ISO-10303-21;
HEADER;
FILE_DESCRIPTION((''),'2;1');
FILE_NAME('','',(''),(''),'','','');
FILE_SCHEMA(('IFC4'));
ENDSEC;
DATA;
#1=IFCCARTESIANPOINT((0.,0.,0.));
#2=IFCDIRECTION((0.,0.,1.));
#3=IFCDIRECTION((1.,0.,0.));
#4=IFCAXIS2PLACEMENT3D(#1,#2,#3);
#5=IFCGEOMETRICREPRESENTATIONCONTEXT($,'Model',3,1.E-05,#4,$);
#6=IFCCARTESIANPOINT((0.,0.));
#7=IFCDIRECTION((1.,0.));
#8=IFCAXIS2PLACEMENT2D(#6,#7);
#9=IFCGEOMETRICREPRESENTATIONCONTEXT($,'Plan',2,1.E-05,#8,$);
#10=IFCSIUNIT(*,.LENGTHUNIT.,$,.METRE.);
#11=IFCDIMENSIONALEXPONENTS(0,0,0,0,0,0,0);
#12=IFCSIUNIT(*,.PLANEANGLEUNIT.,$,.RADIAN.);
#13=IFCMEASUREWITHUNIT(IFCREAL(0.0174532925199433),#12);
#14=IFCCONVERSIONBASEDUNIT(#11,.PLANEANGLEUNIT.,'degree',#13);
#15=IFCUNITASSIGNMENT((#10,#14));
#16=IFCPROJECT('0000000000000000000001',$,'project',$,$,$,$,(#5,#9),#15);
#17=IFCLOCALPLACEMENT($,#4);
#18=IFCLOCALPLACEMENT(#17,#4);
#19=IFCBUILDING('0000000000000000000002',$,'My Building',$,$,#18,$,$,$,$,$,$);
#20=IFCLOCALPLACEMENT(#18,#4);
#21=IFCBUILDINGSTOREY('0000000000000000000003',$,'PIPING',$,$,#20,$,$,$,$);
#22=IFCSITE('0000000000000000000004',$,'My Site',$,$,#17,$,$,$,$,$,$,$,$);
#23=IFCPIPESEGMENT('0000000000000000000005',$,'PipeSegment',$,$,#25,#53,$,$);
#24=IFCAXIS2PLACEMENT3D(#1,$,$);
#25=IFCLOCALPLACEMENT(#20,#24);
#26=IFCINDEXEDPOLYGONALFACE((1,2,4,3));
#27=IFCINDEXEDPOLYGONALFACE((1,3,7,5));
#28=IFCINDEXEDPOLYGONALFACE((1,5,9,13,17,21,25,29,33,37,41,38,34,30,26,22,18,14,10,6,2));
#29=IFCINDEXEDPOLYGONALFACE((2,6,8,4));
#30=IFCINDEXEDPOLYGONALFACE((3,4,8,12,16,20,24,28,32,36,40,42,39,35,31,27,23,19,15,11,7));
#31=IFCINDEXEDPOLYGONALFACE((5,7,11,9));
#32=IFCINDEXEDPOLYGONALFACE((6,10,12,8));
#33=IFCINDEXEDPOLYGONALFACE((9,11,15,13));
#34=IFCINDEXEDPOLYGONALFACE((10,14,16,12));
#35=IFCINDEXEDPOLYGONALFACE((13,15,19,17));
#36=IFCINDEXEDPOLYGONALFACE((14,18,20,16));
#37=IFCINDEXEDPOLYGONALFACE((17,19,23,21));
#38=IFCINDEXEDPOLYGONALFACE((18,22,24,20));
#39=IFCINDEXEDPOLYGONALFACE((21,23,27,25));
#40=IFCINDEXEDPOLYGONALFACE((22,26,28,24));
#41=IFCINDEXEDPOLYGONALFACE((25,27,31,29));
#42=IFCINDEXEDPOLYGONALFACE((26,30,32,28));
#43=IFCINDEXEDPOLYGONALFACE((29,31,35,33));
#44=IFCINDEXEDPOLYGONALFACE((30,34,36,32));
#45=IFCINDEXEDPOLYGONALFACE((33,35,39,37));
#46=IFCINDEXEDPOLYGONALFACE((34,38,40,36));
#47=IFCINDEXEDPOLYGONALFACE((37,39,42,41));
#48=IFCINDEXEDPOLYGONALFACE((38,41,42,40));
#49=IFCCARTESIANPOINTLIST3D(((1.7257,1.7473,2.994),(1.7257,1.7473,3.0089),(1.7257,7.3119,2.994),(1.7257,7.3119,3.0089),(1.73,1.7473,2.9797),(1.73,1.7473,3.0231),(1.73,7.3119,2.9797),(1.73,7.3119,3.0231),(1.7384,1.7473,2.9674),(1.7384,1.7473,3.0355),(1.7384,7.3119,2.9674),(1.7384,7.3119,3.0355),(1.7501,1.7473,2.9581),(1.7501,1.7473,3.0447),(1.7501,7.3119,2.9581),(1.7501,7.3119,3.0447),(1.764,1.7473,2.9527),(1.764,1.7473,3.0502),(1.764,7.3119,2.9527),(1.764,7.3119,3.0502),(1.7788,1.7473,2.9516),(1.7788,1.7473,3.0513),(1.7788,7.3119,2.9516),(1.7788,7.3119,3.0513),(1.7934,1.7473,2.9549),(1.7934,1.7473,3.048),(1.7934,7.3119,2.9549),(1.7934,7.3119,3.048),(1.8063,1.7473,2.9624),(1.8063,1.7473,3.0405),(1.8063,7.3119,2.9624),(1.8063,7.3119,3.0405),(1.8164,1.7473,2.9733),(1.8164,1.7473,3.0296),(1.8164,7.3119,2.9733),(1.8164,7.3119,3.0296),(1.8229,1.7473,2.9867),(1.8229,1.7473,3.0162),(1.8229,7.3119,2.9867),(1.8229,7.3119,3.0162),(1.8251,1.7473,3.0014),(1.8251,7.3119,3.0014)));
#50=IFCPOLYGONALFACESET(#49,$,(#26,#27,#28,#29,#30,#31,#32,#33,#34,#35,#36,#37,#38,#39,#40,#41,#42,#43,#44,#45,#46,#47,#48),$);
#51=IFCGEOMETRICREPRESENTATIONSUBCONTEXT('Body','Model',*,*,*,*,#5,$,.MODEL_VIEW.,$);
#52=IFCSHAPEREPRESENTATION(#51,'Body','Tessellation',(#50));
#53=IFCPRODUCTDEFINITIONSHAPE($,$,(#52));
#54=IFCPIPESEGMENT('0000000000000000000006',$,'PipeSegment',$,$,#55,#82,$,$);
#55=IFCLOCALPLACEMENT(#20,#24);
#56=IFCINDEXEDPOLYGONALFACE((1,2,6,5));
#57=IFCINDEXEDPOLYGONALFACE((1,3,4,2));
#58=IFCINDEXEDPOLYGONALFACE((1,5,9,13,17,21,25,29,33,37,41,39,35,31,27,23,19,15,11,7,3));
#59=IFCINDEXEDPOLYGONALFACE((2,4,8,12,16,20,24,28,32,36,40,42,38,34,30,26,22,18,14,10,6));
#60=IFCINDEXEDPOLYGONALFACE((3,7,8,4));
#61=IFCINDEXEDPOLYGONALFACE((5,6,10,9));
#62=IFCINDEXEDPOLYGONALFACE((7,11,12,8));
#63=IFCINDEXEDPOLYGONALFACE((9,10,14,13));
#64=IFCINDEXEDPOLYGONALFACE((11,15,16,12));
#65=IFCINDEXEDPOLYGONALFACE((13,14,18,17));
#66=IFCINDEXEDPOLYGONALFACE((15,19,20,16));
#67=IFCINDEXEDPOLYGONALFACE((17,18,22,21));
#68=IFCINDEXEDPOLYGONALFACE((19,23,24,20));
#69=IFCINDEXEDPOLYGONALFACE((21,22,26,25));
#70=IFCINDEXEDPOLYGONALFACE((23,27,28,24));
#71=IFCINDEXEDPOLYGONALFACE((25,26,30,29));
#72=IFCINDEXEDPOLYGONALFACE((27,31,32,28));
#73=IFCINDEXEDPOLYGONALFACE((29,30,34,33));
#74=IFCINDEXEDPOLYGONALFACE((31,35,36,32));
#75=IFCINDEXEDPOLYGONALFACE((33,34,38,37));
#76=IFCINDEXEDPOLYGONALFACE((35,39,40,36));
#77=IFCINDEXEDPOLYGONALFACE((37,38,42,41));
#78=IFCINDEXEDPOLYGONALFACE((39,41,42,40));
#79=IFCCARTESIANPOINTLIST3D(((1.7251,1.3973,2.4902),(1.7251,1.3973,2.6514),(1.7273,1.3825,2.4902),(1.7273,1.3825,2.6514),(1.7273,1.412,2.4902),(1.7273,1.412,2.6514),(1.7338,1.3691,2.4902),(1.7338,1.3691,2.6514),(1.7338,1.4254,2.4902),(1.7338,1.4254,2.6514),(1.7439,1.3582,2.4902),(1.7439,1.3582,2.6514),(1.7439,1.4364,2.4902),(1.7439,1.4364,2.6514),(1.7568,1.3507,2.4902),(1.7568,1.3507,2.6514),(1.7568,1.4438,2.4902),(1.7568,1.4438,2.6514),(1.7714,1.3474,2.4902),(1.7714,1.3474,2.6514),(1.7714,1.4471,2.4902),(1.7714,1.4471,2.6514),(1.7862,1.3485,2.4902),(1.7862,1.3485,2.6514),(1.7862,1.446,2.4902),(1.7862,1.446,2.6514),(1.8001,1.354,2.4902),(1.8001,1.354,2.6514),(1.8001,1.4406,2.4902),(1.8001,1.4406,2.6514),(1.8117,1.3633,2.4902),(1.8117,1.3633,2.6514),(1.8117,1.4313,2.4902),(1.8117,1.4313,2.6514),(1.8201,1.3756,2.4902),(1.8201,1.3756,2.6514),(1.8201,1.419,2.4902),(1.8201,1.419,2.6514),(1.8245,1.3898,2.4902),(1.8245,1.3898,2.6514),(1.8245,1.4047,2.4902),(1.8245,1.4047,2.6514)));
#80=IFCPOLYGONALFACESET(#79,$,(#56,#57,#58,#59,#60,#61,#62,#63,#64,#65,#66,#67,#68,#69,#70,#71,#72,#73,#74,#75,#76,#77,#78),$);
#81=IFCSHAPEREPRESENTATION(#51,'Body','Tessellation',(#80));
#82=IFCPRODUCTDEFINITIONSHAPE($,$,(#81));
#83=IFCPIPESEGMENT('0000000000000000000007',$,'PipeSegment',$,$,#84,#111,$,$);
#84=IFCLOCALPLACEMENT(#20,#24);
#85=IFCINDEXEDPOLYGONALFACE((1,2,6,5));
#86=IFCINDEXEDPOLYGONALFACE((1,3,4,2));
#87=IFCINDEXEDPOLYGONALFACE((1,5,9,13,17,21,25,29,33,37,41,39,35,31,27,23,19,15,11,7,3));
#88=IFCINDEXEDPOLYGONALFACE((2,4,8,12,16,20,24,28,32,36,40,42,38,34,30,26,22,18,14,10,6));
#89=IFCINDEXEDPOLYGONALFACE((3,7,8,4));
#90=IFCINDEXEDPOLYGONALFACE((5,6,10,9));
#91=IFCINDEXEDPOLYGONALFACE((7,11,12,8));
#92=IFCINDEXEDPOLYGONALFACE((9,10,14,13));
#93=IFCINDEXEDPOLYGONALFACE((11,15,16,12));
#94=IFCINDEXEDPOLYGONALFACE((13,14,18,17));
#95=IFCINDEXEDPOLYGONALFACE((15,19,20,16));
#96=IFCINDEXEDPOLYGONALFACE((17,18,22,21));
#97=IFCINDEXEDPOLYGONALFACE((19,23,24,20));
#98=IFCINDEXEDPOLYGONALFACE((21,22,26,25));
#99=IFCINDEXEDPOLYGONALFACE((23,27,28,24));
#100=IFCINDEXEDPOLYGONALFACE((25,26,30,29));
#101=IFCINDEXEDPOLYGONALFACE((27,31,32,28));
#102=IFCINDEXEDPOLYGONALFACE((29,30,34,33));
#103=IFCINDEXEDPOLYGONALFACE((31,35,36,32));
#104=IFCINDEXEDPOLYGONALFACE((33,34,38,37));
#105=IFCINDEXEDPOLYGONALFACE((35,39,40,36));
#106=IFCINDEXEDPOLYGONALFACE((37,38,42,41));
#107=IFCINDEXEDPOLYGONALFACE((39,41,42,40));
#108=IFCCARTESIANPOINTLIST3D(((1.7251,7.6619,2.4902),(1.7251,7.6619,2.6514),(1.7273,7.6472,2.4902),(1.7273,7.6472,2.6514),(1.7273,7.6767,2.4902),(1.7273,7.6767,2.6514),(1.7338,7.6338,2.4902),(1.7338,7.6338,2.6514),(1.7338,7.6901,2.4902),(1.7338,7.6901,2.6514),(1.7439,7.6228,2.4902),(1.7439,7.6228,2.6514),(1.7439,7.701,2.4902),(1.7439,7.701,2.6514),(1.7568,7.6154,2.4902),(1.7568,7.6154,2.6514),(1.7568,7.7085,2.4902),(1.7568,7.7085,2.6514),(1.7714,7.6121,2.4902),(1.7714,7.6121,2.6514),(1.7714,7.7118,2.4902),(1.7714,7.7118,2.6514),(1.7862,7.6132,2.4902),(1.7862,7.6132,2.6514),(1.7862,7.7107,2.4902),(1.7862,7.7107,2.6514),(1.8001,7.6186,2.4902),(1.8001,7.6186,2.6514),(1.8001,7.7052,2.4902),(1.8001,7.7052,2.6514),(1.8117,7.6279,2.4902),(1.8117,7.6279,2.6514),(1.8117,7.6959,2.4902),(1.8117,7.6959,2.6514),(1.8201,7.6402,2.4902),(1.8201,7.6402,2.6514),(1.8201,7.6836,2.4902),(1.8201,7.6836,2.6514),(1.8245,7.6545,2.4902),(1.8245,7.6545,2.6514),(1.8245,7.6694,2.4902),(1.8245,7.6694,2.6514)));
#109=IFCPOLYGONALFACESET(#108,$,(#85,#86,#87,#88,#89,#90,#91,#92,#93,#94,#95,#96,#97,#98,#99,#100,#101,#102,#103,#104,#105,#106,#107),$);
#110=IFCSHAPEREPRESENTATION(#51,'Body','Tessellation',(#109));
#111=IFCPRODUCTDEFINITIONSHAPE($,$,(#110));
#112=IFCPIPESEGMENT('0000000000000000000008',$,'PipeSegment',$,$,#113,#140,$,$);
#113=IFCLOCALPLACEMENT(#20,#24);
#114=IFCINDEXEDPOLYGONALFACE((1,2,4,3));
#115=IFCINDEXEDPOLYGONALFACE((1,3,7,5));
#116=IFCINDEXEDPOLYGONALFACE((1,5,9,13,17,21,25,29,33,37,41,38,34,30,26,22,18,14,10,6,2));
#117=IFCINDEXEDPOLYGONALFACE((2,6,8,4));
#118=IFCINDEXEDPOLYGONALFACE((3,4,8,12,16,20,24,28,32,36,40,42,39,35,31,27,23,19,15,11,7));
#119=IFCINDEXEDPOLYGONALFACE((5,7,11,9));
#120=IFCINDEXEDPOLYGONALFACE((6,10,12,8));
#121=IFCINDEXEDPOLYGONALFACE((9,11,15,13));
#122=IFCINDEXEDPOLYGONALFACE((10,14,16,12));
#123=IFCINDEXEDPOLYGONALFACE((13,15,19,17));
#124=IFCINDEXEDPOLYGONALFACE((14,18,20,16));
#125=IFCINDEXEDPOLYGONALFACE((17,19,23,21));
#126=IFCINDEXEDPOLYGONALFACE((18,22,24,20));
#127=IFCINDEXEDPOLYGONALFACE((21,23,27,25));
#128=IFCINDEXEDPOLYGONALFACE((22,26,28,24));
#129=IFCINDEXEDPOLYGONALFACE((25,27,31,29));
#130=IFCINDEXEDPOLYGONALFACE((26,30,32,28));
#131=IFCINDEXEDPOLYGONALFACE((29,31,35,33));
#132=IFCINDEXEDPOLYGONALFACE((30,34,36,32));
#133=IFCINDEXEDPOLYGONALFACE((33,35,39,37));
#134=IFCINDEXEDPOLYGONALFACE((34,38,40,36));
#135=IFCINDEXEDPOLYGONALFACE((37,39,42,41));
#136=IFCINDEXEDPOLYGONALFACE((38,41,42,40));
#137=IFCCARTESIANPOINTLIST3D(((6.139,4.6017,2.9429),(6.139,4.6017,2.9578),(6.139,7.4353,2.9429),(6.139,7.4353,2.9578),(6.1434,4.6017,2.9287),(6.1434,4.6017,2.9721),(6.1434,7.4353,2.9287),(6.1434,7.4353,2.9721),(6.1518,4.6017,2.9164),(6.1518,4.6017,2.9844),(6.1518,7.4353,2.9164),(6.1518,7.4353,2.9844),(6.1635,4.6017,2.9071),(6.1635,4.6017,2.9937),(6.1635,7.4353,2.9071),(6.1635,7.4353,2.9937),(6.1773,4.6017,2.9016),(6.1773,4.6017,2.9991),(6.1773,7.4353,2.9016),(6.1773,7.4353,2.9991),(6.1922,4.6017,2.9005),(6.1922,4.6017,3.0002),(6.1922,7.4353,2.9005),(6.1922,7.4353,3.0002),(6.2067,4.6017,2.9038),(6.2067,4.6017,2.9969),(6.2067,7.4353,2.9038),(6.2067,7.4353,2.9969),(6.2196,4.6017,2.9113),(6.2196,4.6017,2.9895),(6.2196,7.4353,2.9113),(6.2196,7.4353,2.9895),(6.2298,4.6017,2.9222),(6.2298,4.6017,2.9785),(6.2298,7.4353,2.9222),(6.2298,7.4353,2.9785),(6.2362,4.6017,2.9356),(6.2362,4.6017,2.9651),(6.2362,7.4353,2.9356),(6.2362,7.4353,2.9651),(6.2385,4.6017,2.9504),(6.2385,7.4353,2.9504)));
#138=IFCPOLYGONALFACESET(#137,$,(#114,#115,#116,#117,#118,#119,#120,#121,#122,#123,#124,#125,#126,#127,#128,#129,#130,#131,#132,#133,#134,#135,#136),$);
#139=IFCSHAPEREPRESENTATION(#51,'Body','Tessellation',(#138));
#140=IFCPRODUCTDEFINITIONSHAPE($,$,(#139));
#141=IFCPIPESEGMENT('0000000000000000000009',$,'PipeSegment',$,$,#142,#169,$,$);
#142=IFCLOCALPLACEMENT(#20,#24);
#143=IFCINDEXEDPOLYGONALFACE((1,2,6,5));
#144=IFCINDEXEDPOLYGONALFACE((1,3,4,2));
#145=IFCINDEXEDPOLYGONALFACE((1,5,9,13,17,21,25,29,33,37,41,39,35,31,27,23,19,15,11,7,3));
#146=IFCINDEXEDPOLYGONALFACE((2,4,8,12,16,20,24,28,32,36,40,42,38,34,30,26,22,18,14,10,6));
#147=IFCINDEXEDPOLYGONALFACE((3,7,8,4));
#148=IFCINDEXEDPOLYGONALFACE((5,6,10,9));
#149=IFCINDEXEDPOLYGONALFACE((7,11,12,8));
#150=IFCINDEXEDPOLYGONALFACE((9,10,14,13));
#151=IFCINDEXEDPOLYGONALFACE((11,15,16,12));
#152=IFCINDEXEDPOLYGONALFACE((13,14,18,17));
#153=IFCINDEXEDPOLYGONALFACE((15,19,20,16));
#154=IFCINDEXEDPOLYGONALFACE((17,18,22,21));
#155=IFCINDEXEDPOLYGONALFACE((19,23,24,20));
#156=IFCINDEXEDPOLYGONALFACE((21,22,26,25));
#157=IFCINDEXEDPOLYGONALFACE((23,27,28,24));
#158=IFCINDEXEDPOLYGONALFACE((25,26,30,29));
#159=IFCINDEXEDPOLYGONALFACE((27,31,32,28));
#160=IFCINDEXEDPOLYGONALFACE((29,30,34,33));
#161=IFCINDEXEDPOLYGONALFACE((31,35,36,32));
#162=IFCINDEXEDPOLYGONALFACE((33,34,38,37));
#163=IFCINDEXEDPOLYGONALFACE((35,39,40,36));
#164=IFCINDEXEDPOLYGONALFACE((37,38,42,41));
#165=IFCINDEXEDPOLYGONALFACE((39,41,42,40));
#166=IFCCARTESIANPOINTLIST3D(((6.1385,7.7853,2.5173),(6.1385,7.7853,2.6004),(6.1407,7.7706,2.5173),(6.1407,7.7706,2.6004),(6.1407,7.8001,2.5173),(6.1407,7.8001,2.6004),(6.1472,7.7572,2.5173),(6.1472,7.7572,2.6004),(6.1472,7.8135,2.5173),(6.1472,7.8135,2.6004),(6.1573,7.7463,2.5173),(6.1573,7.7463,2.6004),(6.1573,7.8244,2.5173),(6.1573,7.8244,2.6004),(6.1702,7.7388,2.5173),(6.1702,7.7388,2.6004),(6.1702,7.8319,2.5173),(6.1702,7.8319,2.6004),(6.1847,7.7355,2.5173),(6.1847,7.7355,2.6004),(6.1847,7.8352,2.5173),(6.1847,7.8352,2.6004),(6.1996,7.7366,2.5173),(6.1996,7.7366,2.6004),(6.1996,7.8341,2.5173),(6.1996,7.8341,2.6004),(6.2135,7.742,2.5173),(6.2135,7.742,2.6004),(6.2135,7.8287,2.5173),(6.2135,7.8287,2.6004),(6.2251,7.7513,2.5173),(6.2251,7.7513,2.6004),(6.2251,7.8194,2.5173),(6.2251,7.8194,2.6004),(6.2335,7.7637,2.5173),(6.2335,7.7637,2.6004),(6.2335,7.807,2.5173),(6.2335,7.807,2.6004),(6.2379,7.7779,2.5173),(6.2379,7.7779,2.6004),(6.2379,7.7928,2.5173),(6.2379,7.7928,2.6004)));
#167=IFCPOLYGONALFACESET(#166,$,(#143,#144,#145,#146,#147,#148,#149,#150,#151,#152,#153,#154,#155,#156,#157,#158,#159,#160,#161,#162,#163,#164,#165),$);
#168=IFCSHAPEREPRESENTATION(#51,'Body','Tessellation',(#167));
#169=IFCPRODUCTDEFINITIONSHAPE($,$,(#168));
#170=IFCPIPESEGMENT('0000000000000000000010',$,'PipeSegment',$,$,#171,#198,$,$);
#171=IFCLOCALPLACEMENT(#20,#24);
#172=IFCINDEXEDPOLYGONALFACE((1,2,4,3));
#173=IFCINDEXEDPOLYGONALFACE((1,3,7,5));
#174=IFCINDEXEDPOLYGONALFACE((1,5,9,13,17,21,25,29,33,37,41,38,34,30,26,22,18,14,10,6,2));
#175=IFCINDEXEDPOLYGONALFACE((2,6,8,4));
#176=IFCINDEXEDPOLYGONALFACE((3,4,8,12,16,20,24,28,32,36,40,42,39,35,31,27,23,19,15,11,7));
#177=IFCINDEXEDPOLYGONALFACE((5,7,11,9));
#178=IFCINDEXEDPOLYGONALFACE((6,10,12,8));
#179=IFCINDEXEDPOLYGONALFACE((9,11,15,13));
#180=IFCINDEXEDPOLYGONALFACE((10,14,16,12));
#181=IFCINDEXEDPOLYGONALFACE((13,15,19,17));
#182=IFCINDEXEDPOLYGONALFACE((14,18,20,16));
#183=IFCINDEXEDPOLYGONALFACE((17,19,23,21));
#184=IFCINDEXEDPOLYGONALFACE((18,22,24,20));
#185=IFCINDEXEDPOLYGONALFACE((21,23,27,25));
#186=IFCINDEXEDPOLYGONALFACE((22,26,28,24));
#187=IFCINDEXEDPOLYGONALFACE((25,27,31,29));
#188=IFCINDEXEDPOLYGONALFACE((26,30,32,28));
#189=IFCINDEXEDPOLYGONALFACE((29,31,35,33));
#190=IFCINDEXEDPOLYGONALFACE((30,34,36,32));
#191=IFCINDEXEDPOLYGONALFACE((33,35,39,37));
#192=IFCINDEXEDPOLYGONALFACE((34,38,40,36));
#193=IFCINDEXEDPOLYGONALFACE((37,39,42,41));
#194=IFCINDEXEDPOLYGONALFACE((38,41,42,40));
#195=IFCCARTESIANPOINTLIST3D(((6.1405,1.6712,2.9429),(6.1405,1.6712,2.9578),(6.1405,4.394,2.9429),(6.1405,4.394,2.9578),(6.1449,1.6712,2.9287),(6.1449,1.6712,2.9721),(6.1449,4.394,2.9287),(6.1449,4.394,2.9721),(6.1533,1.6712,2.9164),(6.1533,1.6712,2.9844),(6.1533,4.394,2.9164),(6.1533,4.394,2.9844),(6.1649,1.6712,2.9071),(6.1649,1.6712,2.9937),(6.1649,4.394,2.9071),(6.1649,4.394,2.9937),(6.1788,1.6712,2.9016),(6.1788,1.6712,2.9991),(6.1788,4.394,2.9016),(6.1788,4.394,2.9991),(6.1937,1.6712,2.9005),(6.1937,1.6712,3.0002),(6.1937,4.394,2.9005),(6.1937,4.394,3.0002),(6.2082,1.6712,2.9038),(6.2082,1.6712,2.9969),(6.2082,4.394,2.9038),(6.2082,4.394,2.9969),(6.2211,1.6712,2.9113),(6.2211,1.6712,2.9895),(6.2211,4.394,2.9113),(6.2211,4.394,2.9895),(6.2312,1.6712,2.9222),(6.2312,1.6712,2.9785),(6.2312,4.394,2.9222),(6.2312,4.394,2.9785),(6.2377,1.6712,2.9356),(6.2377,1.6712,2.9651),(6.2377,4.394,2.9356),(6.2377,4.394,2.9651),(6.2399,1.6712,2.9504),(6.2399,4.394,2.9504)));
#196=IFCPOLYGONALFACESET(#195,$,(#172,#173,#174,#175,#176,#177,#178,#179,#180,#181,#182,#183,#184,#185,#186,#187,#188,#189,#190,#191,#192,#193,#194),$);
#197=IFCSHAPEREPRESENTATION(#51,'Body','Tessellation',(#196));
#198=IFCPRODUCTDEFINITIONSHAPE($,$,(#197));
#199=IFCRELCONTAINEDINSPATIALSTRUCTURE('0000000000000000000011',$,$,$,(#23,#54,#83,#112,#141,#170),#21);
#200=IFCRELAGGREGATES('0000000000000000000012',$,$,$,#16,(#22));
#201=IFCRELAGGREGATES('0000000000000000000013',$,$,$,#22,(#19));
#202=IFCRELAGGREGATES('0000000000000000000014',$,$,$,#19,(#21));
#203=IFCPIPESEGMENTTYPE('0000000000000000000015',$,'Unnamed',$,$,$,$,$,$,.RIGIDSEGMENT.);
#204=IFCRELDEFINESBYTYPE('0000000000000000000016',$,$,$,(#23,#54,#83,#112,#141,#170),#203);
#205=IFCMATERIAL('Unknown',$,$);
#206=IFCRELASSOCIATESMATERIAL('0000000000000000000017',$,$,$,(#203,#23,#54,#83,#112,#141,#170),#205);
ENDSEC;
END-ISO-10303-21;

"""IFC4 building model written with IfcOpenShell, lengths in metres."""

from ifc_helpers import new_model, entity, si_unit, converted_unit, frame, origin_with_axes, origin_2d_with_axis, place, context, subcontext, project, spatial, circle, extrude, material, material_profile, profile_set, profile_usage, type_object, element, save


model = new_model("IFC4")

# Units and contexts
model_context = context("Model", 3, precision=1e-05, world=origin_with_axes())
plan_context = context("Plan", 2, precision=1e-05, world=origin_2d_with_axis())
body_context = subcontext(model_context, "Body", "Model", "MODEL_VIEW")
ifc_project = project(units=[si_unit("LENGTHUNIT", "METRE"), converted_unit("PLANEANGLEUNIT", "degree", entity("IfcReal", 0.0174532925199433), si_unit("PLANEANGLEUNIT", "RADIAN"), dimensions=[0, 0, 0, 0, 0, 0, 0])], contexts=[model_context, plan_context])

# Site, building, storey
site_placement = place(None, origin_with_axes())
site = spatial("IfcSite", under=ifc_project, at=site_placement, Name="My Site")
building_placement = place(site_placement, origin_with_axes())
building = spatial("IfcBuilding", under=site, at=building_placement, Name="My Building")
storey_placement = place(building_placement, origin_with_axes())
storey = spatial("IfcBuildingStorey", under=building, at=storey_placement, Name="PIPING")

# Pipe segments
ifc_material = material(Name="Unknown")
ifc_material_profile_1 = material_profile(ifc_material, circle(Radius=0.05))
ifc_profile_set_1 = profile_set([ifc_material_profile_1])
ifc_profile_usage_1 = profile_usage(ifc_profile_set_1, cardinal=5)
pipe_segment_type = type_object("IfcPipeSegmentType", Name="Unnamed", PredefinedType="RIGIDSEGMENT", material=ifc_profile_set_1)
pipe_segment_1_placement = place(storey_placement, frame((1.7751, 1.7473, 3.0014), z_axis=(0.0, 1.0, 0.0), x_axis=(1.0, 0.0, 0.0)))
element("IfcPipeSegment", 1, at=pipe_segment_1_placement, inside=storey, type_object=pipe_segment_type, material=ifc_profile_usage_1, Name="PipeSegment", context=body_context, shape_type="SweptSolid", body=[
    extrude(circle(Radius=0.05), origin_with_axes(), (0.0, 0.0, 1.0), 5.5647),
])
ifc_profile_usage_2 = profile_usage(ifc_profile_set_1, cardinal=5)
pipe_segment_2_placement = place(storey_placement, frame((1.7751, 1.3973, 2.6514), z_axis=(0.0, 0.0, -1.0), x_axis=(-1.0, 0.0, 0.0)))
element("IfcPipeSegment", 2, at=pipe_segment_2_placement, inside=storey, type_object=pipe_segment_type, material=ifc_profile_usage_2, Name="PipeSegment", context=body_context, shape_type="SweptSolid", body=[
    extrude(circle(Radius=0.05), origin_with_axes(), (0.0, 0.0, 1.0), 0.1612),
])
ifc_profile_usage_3 = profile_usage(ifc_profile_set_1, cardinal=5)
pipe_segment_3_placement = place(storey_placement, frame((1.7751, 7.6619, 2.6514), z_axis=(0.0, 0.0, -1.0), x_axis=(-1.0, 0.0, 0.0)))
element("IfcPipeSegment", 3, at=pipe_segment_3_placement, inside=storey, type_object=pipe_segment_type, material=ifc_profile_usage_3, Name="PipeSegment", context=body_context, shape_type="SweptSolid", body=[
    extrude(circle(Radius=0.05), origin_with_axes(), (0.0, 0.0, 1.0), 0.1612),
])
ifc_profile_usage_4 = profile_usage(ifc_profile_set_1, cardinal=5)
pipe_segment_4_placement = place(storey_placement, frame((6.1885, 4.6017, 2.9504), z_axis=(0.0, 1.0, 0.0), x_axis=(1.0, 0.0, 0.0)))
element("IfcPipeSegment", 4, at=pipe_segment_4_placement, inside=storey, type_object=pipe_segment_type, material=ifc_profile_usage_4, Name="PipeSegment", context=body_context, shape_type="SweptSolid", body=[
    extrude(circle(Radius=0.05), origin_with_axes(), (0.0, 0.0, 1.0), 2.8337),
])
ifc_profile_usage_5 = profile_usage(ifc_profile_set_1, cardinal=5)
pipe_segment_5_placement = place(storey_placement, frame((6.1885, 7.7853, 2.6004), z_axis=(0.0, 0.0, -1.0), x_axis=(-1.0, 0.0, 0.0)))
element("IfcPipeSegment", 5, at=pipe_segment_5_placement, inside=storey, type_object=pipe_segment_type, material=ifc_profile_usage_5, Name="PipeSegment", context=body_context, shape_type="SweptSolid", body=[
    extrude(circle(Radius=0.05), origin_with_axes(), (0.0, 0.0, 1.0), 0.0831),
])
ifc_profile_usage_6 = profile_usage(ifc_profile_set_1, cardinal=5)
pipe_segment_6_placement = place(storey_placement, frame((6.1899, 1.6712, 2.9504), z_axis=(0.0, 1.0, 0.0), x_axis=(1.0, 0.0, 0.0)))
element("IfcPipeSegment", 6, at=pipe_segment_6_placement, inside=storey, type_object=pipe_segment_type, material=ifc_profile_usage_6, Name="PipeSegment", context=body_context, shape_type="SweptSolid", body=[
    extrude(circle(Radius=0.05), origin_with_axes(), (0.0, 0.0, 1.0), 2.7228),
])

save(model, "model.ifc")
